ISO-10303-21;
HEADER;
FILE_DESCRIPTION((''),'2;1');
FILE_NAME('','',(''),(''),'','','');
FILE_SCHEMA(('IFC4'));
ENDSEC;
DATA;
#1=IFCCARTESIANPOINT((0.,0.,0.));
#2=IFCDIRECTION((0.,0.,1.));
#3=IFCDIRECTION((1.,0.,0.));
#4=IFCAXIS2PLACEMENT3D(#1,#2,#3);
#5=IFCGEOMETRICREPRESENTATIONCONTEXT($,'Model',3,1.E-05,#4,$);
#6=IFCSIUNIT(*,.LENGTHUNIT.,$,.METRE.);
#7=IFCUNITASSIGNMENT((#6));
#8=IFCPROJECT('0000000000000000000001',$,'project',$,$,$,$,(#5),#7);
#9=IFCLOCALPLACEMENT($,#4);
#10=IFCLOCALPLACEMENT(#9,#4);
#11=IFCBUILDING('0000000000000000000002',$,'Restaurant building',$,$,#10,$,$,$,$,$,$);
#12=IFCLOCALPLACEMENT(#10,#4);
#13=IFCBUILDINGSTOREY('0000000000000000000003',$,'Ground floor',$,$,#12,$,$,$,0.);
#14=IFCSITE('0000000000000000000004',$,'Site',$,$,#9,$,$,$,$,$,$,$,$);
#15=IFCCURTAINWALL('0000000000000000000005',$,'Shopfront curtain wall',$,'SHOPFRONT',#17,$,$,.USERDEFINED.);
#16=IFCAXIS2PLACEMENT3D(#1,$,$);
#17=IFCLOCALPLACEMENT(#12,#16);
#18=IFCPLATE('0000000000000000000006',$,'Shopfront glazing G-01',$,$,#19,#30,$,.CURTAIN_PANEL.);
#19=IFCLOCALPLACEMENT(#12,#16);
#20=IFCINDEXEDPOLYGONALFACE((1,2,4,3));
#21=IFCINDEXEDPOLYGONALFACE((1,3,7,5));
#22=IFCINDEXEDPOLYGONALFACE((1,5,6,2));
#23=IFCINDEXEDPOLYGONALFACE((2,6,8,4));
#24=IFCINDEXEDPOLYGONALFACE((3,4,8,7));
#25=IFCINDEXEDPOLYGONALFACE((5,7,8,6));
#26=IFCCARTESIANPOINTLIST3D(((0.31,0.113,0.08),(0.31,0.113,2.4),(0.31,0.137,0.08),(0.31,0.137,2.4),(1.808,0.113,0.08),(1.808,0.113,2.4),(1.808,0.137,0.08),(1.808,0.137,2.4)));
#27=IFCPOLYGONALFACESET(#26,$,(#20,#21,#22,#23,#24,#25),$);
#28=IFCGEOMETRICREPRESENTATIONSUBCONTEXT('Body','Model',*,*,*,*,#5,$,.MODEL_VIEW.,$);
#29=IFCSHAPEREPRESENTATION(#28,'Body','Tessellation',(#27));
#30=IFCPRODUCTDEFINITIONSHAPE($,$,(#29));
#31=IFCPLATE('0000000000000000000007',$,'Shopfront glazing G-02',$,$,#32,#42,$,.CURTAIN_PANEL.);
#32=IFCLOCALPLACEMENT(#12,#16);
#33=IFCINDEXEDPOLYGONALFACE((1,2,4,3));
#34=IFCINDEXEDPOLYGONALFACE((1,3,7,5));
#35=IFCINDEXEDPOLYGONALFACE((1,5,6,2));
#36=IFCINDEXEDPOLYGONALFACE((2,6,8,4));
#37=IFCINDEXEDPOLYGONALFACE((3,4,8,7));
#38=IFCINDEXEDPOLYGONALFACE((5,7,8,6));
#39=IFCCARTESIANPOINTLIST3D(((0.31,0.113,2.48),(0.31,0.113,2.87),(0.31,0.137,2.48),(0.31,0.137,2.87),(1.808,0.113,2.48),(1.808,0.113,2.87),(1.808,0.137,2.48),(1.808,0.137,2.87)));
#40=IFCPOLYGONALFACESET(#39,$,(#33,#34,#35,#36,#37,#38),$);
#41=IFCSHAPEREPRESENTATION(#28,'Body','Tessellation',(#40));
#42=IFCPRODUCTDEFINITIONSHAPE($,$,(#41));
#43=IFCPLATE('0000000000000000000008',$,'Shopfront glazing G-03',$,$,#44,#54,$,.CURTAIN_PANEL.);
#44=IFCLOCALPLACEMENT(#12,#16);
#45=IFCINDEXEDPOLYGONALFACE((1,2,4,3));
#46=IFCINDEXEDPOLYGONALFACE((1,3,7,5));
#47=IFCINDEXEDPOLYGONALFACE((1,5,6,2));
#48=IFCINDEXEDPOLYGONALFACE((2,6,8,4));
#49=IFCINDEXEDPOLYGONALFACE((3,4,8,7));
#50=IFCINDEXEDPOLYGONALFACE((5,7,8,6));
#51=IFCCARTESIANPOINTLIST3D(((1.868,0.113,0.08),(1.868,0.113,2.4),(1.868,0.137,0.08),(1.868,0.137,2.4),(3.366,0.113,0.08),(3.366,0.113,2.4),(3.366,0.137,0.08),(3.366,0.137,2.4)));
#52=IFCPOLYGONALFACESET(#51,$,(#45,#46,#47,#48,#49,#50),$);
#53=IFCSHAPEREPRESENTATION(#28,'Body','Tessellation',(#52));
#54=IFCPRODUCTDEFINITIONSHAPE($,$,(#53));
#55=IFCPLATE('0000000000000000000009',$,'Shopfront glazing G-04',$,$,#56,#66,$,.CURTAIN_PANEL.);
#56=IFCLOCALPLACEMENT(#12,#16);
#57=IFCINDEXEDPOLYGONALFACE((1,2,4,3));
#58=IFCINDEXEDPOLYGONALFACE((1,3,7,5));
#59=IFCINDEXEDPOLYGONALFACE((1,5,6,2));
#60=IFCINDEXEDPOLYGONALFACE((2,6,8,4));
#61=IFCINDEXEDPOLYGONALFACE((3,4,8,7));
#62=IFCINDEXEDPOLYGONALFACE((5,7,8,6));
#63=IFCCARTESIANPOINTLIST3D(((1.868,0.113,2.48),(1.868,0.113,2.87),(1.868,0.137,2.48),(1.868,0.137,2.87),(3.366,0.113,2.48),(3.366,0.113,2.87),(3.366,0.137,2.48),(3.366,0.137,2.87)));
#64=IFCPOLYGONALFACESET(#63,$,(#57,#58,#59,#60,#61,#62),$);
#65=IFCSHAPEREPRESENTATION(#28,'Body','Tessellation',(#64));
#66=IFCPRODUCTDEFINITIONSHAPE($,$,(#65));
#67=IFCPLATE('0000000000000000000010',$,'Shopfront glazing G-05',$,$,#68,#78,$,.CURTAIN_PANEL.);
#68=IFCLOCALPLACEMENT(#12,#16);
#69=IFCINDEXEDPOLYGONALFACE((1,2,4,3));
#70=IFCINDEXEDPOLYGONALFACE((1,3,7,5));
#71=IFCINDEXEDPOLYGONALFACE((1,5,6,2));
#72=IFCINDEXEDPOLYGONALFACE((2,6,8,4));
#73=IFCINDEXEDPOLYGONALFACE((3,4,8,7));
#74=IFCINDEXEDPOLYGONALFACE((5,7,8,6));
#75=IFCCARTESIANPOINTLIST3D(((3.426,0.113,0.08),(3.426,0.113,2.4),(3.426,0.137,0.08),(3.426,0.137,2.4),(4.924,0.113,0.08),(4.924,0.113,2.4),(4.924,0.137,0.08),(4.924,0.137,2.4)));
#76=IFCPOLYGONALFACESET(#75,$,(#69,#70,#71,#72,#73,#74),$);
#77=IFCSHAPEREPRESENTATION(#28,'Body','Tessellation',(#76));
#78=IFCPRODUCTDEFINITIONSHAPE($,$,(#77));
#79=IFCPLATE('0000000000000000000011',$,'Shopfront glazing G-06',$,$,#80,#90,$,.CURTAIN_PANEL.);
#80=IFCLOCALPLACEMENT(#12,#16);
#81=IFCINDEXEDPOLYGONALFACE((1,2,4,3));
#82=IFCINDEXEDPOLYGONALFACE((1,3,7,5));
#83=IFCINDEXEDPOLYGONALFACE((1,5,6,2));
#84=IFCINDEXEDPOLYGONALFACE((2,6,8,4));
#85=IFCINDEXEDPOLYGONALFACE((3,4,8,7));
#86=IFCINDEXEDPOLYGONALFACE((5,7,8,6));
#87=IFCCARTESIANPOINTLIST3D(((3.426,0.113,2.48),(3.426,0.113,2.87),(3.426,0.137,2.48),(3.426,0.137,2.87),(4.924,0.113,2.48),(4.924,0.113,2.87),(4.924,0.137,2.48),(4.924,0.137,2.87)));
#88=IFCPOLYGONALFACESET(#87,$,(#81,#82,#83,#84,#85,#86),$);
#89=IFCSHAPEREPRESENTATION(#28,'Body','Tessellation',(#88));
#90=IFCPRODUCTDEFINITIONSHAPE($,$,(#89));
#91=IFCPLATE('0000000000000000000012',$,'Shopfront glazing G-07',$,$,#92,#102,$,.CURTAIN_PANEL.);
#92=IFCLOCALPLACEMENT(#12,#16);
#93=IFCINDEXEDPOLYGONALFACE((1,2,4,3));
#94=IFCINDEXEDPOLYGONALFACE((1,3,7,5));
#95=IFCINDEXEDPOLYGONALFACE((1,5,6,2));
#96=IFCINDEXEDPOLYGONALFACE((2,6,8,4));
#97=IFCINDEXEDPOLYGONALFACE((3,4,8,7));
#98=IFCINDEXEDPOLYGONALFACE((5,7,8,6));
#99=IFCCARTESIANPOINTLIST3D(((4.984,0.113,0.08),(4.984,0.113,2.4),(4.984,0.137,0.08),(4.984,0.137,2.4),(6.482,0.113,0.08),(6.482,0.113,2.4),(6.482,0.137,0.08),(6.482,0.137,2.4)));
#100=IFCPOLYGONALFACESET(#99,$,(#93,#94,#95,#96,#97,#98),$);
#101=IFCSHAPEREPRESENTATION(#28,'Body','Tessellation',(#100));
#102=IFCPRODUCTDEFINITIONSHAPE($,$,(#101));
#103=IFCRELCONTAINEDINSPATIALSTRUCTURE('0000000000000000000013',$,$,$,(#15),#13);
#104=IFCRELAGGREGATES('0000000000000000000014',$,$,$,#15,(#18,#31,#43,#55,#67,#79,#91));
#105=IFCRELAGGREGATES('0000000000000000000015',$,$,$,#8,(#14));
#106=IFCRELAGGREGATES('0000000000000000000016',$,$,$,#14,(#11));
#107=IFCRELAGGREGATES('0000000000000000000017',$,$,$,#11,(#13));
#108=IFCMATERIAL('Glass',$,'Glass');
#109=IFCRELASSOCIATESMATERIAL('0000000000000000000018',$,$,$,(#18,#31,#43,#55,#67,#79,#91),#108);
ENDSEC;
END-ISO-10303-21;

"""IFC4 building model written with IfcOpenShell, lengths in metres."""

from ifc_helpers import new_model, si_unit, frame, origin, origin_with_axes, origin_2d, place, context, subcontext, project, spatial, rectangle, extrude, material, element, aggregate, save


model = new_model("IFC4")

# Units and contexts
model_context = context("Model", 3, precision=1e-05, world=origin_with_axes())
body_context = subcontext(model_context, "Body", "Model", "MODEL_VIEW")
ifc_project = project(units=[si_unit("LENGTHUNIT", "METRE")], contexts=[model_context])

# Site, building, storey
site_placement = place(None, origin_with_axes())
site = spatial("IfcSite", under=ifc_project, at=site_placement, Name="Site")
building_placement = place(site_placement, origin_with_axes())
building = spatial("IfcBuilding", under=site, at=building_placement, Name="Restaurant building")
storey_placement = place(building_placement, origin_with_axes())
storey = spatial("IfcBuildingStorey", under=building, at=storey_placement, Name="Ground floor", Elevation=0.0)

# Curtain wall, plates
curtain_wall_placement = place(storey_placement, origin())
curtain_wall = element("IfcCurtainWall", 1, at=curtain_wall_placement, inside=storey, Name="Shopfront curtain wall", ObjectType="SHOPFRONT", PredefinedType="USERDEFINED")
ifc_material_1 = material(Name="Glass", Category="Glass")
plate_1_placement = place(curtain_wall_placement, origin_with_axes())
plate_1 = element("IfcPlate", 2, at=plate_1_placement, material=ifc_material_1, Name="Shopfront glazing G-01", PredefinedType="CURTAIN_PANEL", context=body_context, shape_type="SweptSolid", body=[
    extrude(rectangle(XDim=1.498, YDim=0.024, at=origin_2d()), frame((1.059, 0.125, 0.08)), (0.0, 0.0, 1.0), 2.32),
])
plate_2_placement = place(curtain_wall_placement, origin_with_axes())
plate_2 = element("IfcPlate", 3, at=plate_2_placement, material=ifc_material_1, Name="Shopfront glazing G-02", PredefinedType="CURTAIN_PANEL", context=body_context, shape_type="SweptSolid", body=[
    extrude(rectangle(XDim=1.498, YDim=0.024, at=origin_2d()), frame((1.059, 0.125, 2.48)), (0.0, 0.0, 1.0), 0.39),
])
plate_3_placement = place(curtain_wall_placement, origin_with_axes())
plate_3 = element("IfcPlate", 4, at=plate_3_placement, material=ifc_material_1, Name="Shopfront glazing G-03", PredefinedType="CURTAIN_PANEL", context=body_context, shape_type="SweptSolid", body=[
    extrude(rectangle(XDim=1.498, YDim=0.024, at=origin_2d()), frame((2.617, 0.125, 0.08)), (0.0, 0.0, 1.0), 2.32),
])
plate_4_placement = place(curtain_wall_placement, origin_with_axes())
plate_4 = element("IfcPlate", 5, at=plate_4_placement, material=ifc_material_1, Name="Shopfront glazing G-04", PredefinedType="CURTAIN_PANEL", context=body_context, shape_type="SweptSolid", body=[
    extrude(rectangle(XDim=1.498, YDim=0.024, at=origin_2d()), frame((2.617, 0.125, 2.48)), (0.0, 0.0, 1.0), 0.39),
])
plate_5_placement = place(curtain_wall_placement, origin_with_axes())
plate_5 = element("IfcPlate", 6, at=plate_5_placement, material=ifc_material_1, Name="Shopfront glazing G-05", PredefinedType="CURTAIN_PANEL", context=body_context, shape_type="SweptSolid", body=[
    extrude(rectangle(XDim=1.498, YDim=0.024, at=origin_2d()), frame((4.175, 0.125, 0.08)), (0.0, 0.0, 1.0), 2.32),
])
plate_6_placement = place(curtain_wall_placement, origin_with_axes())
plate_6 = element("IfcPlate", 7, at=plate_6_placement, material=ifc_material_1, Name="Shopfront glazing G-06", PredefinedType="CURTAIN_PANEL", context=body_context, shape_type="SweptSolid", body=[
    extrude(rectangle(XDim=1.498, YDim=0.024, at=origin_2d()), frame((4.175, 0.125, 2.48)), (0.0, 0.0, 1.0), 0.39),
])
plate_7_placement = place(curtain_wall_placement, origin_with_axes())
plate_7 = element("IfcPlate", 8, at=plate_7_placement, material=ifc_material_1, Name="Shopfront glazing G-07", PredefinedType="CURTAIN_PANEL", context=body_context, shape_type="SweptSolid", body=[
    extrude(rectangle(XDim=1.498, YDim=0.024, at=origin_2d()), frame((5.733, 0.125, 0.08)), (0.0, 0.0, 1.0), 2.32),
])
aggregate(curtain_wall, [plate_1, plate_2, plate_3, plate_4, plate_5, plate_6, plate_7])

save(model, "model.ifc")
